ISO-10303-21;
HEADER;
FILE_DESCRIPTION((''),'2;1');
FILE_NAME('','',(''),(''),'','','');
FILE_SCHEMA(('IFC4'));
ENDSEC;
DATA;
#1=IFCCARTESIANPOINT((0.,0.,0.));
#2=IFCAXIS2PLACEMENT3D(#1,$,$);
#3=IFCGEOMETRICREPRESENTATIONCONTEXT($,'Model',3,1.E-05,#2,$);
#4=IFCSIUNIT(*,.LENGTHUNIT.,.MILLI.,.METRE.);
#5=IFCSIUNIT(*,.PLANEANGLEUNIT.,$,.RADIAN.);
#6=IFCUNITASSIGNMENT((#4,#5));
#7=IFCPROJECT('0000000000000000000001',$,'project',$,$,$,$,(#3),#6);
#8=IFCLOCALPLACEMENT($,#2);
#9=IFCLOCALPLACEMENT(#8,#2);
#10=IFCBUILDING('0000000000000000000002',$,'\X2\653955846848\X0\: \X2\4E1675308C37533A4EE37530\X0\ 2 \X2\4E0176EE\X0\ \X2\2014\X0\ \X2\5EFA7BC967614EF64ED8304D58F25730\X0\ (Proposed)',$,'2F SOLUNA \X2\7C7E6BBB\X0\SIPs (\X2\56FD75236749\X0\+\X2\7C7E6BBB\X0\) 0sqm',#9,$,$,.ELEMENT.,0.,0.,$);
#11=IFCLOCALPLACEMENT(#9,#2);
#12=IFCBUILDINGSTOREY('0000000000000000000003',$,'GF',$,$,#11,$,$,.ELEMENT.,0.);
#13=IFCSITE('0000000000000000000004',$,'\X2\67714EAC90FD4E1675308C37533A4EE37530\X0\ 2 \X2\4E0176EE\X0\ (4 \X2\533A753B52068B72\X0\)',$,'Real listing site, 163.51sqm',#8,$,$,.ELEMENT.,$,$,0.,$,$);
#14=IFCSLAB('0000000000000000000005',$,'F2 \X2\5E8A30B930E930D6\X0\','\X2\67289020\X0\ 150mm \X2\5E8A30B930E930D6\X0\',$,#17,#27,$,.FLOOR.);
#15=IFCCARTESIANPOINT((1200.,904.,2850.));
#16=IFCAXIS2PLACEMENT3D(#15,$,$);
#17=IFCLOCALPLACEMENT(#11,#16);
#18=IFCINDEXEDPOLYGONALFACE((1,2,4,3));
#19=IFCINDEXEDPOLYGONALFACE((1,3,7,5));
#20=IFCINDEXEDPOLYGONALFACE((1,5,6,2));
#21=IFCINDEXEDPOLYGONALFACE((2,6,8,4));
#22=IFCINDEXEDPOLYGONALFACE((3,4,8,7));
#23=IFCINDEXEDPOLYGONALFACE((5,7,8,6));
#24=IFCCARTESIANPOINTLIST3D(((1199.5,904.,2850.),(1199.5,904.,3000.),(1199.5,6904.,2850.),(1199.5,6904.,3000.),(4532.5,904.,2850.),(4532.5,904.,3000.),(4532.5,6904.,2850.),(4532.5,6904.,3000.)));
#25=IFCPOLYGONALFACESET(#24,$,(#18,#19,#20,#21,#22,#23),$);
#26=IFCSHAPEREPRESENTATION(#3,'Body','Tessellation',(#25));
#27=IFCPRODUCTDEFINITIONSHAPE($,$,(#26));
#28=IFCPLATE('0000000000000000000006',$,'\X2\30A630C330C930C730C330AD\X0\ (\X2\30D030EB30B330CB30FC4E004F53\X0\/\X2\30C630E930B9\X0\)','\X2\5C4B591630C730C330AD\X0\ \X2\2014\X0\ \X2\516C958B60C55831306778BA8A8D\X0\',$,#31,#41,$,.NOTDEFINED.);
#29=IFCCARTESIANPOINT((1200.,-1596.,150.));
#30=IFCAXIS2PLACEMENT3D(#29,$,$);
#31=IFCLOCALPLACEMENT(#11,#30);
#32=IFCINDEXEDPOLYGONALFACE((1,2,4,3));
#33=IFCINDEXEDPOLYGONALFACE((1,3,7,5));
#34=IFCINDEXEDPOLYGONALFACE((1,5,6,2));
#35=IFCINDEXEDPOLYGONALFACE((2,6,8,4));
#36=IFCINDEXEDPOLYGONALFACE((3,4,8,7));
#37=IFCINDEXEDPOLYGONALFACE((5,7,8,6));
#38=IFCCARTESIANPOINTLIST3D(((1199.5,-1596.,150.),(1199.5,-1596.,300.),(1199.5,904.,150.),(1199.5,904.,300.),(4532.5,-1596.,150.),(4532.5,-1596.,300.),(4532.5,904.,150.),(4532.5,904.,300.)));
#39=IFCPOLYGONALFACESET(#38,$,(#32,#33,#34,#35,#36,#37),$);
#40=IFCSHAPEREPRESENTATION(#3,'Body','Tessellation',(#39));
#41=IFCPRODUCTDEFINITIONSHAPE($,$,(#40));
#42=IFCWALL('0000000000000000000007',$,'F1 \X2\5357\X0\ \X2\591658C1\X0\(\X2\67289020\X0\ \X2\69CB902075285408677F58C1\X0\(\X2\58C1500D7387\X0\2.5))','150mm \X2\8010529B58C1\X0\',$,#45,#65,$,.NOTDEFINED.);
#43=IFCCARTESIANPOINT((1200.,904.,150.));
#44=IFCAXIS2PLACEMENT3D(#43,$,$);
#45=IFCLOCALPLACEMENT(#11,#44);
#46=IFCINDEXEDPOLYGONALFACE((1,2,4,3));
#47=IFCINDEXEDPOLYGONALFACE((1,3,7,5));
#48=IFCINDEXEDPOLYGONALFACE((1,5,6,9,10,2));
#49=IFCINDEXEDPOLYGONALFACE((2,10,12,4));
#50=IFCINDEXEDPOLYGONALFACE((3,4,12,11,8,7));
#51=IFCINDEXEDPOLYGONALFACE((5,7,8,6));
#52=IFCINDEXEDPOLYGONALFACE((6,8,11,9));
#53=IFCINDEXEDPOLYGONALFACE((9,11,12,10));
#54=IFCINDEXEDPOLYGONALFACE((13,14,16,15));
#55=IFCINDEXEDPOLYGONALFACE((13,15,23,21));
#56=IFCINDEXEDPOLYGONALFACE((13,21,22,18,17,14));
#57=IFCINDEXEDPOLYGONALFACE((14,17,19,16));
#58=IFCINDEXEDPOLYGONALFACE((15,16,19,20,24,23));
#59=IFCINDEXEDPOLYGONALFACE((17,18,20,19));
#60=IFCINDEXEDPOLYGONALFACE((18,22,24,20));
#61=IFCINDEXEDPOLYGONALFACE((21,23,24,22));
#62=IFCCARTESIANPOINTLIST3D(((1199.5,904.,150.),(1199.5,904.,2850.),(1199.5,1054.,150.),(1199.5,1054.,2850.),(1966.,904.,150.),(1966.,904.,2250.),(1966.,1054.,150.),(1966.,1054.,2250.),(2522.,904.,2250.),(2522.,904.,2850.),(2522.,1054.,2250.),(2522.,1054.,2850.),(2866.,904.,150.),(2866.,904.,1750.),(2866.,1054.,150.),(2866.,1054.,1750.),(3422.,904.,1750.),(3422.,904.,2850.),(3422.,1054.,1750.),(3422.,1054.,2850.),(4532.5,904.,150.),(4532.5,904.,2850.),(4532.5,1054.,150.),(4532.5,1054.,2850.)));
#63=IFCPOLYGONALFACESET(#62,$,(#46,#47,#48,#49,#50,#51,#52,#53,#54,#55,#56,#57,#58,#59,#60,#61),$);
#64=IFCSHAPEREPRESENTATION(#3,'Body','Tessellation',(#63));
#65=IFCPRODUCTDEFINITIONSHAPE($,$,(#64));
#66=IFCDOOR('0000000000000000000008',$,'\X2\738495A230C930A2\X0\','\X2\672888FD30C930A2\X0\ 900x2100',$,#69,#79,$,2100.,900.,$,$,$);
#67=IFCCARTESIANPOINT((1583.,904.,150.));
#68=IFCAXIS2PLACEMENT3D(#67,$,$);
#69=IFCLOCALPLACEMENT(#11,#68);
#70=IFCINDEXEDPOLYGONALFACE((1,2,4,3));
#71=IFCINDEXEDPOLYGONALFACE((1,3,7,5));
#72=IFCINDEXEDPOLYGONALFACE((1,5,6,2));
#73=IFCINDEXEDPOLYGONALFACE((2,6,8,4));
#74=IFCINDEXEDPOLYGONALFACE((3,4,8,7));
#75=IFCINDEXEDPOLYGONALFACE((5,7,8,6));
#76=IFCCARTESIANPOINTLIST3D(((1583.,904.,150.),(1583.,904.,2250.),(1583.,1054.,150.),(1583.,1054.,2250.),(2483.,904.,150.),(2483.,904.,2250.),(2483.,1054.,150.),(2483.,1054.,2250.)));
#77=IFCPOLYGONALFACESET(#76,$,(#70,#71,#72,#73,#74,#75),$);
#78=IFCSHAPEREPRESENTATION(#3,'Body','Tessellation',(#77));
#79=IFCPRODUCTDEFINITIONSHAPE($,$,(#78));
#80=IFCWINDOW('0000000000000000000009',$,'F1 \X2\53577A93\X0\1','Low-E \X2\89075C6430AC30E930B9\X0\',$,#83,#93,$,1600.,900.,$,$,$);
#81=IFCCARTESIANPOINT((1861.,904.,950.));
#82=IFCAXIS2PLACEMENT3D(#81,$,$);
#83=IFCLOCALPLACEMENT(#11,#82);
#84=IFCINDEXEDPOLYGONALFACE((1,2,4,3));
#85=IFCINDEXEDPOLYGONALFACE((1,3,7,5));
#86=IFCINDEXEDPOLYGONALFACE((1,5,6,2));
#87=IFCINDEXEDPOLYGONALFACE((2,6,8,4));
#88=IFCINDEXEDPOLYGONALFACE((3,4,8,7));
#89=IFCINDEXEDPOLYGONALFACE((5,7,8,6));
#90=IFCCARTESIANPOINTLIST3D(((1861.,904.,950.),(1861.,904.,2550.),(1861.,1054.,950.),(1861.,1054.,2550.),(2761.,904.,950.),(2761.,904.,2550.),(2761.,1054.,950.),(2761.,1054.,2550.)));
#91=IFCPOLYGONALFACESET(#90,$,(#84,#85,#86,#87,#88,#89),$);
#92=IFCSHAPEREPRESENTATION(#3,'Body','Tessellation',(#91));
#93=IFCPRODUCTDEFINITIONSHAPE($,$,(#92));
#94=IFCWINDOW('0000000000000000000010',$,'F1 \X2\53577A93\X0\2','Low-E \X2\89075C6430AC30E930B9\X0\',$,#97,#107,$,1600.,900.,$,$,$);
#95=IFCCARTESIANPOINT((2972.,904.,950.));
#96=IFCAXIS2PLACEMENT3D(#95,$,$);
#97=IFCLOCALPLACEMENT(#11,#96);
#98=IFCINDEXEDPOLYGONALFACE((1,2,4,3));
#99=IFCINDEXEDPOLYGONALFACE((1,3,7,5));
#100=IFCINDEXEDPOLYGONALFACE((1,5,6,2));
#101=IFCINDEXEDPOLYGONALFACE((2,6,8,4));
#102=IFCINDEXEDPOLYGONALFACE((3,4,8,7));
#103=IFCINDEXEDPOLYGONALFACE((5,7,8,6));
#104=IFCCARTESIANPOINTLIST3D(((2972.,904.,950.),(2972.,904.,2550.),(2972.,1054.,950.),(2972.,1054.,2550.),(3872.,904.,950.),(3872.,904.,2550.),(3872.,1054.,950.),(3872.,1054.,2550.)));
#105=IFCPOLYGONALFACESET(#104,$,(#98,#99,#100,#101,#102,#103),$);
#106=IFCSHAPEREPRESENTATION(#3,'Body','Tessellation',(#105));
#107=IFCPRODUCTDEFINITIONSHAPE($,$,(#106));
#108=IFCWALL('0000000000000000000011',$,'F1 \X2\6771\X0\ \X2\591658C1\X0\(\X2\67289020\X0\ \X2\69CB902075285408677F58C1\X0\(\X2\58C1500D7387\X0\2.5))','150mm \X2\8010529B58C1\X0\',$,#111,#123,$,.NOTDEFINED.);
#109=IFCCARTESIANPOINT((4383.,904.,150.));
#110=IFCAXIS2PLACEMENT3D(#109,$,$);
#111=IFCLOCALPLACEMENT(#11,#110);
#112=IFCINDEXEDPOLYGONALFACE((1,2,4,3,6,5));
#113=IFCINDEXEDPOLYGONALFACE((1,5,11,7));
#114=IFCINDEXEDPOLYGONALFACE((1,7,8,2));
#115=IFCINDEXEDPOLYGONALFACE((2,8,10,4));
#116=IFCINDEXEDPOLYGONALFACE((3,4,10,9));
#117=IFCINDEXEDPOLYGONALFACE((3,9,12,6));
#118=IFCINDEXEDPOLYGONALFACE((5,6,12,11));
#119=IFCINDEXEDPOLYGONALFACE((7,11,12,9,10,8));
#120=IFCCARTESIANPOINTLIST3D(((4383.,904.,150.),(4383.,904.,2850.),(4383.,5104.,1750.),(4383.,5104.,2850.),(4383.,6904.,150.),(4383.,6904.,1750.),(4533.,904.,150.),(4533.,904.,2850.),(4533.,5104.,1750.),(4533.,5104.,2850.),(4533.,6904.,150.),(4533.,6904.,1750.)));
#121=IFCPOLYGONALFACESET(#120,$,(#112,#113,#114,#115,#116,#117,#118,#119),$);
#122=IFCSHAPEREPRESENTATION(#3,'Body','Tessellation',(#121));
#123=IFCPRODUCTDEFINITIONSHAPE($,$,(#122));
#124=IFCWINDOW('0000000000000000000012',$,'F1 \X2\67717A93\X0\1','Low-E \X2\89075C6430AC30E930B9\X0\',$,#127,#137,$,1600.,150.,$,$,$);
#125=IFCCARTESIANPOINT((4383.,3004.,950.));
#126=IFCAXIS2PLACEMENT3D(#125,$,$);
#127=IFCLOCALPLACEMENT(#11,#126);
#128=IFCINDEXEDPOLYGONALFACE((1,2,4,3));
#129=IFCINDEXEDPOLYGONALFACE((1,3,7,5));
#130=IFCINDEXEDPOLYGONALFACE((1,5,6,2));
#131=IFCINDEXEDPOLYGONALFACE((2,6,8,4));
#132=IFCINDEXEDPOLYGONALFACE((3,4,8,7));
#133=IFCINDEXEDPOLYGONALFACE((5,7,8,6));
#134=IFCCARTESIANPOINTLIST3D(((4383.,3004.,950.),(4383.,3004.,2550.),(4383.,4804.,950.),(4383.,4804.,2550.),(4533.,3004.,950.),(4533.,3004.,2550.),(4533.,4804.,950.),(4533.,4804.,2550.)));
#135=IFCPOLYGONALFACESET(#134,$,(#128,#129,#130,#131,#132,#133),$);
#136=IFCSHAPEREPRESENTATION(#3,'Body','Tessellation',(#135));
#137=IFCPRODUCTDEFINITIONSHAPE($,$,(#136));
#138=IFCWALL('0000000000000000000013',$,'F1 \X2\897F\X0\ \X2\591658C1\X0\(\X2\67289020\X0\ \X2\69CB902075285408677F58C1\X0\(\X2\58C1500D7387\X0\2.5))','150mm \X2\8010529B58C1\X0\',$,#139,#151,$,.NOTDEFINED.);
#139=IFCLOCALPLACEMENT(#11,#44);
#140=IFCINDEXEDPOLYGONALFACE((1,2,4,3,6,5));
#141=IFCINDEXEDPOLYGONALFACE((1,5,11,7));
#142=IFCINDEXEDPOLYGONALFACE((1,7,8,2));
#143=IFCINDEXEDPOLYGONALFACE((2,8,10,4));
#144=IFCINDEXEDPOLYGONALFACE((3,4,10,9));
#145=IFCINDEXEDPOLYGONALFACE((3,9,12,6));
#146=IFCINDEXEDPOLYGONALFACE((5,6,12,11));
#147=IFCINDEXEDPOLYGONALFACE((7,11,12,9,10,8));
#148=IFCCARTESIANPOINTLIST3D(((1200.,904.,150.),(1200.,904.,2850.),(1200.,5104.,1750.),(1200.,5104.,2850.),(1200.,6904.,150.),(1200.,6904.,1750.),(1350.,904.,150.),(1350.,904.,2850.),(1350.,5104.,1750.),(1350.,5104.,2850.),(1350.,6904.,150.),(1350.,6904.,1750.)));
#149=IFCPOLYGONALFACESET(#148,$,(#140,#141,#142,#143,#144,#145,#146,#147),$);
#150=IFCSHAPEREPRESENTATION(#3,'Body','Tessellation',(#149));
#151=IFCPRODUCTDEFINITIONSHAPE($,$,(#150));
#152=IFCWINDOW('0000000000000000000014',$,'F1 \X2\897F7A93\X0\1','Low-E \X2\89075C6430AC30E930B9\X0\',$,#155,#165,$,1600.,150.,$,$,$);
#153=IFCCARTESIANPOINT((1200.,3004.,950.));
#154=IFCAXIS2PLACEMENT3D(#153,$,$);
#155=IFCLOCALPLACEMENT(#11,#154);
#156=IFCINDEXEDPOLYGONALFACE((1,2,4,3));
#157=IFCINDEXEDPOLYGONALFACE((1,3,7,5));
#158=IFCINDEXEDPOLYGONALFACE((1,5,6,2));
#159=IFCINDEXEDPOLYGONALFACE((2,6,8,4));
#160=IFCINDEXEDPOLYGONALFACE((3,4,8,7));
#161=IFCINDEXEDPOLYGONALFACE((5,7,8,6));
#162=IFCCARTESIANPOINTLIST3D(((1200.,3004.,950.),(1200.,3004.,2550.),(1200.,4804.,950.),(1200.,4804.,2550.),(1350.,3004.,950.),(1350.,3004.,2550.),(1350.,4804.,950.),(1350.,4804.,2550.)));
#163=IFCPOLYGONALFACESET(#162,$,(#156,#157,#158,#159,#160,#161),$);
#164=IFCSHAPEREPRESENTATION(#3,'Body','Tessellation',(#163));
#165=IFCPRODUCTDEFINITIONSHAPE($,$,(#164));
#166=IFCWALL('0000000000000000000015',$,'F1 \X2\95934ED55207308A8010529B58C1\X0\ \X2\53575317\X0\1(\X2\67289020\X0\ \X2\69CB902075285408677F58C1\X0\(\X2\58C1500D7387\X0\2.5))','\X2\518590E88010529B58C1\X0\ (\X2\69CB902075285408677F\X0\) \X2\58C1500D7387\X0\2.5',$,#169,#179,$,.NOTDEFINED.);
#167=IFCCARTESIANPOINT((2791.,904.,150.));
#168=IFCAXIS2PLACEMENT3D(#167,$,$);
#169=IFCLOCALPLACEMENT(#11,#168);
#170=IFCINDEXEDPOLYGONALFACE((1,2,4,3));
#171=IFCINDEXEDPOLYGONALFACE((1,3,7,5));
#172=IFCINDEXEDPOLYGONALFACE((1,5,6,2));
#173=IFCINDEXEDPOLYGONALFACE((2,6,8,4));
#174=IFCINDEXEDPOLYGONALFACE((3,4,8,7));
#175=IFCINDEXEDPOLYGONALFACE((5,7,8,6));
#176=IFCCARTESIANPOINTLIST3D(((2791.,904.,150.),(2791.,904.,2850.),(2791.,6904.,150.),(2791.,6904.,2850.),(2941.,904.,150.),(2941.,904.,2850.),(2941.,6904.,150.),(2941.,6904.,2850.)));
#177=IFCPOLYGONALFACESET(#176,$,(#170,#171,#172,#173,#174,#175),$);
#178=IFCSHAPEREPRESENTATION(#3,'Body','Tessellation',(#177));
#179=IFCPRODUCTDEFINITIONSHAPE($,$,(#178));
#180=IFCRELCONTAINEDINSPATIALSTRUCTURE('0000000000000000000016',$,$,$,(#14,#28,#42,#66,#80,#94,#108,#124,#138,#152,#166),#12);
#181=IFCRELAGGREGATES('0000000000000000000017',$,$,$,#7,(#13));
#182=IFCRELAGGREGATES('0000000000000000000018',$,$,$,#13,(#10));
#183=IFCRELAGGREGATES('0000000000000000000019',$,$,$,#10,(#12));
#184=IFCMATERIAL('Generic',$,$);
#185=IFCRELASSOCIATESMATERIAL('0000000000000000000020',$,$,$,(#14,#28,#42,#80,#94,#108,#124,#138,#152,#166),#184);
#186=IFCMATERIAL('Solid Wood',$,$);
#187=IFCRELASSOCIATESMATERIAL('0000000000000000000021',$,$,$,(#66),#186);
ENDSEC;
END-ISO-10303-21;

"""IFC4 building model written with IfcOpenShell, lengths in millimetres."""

from ifc_helpers import new_model, si_unit, frame, frame_2d, origin, place, context, project, spatial, rectangle, extrude, material, element, fill, save


model = new_model("IFC4")

# Units and contexts
model_context = context("Model", 3, precision=1e-05, world=origin())
ifc_project = project(units=[si_unit("LENGTHUNIT", "METRE", prefix="MILLI"), si_unit("PLANEANGLEUNIT", "RADIAN")], contexts=[model_context])

# Site, building, storey
site_placement = place(None, origin())
site = spatial("IfcSite", under=ifc_project, at=site_placement, Name="東京都世田谷区代田 2 丁目 (4 区画分譲)", ObjectType="Real listing site, 163.51sqm", CompositionType="ELEMENT", RefElevation=0.0)
building_placement = place(site_placement, origin())
building = spatial("IfcBuilding", under=site, at=building_placement, Name="改善案: 世田谷区代田 2 丁目 — 建築条件付き売地 (Proposed)", ObjectType="2F SOLUNA 籾殻SIPs (国産杉+籾殻) 0sqm", CompositionType="ELEMENT", ElevationOfRefHeight=0.0, ElevationOfTerrain=0.0)
storey_placement = place(building_placement, origin())
storey = spatial("IfcBuildingStorey", under=building, at=storey_placement, Name="GF", CompositionType="ELEMENT", Elevation=0.0)

# Slab
ifc_material_1 = material(Name="Generic")
slab_1_placement = place(storey_placement, frame((1200.0, 904.0, 2850.0)))
element("IfcSlab", 1, at=slab_1_placement, inside=storey, material=ifc_material_1, Name="F2 床スラブ", Description="木造 150mm 床スラブ", PredefinedType="FLOOR", context=model_context, shape_type="SweptSolid", body=[
    extrude(rectangle(XDim=3333.0, YDim=6000.0, at=frame_2d((1666.0, 3000.0))), frame((1200.0, 904.0, 2850.0)), (0.0, 0.0, 1.0), 150.0),
])

# Plate
plate_placement = place(storey_placement, frame((1200.0, -1596.0, 150.0)))
element("IfcPlate", 2, at=plate_placement, inside=storey, material=ifc_material_1, Name="ウッドデッキ (バルコニー一体/テラス)", Description="屋外デッキ — 公開情報で確認", PredefinedType="NOTDEFINED", context=model_context, shape_type="SweptSolid", body=[
    extrude(rectangle(XDim=3333.0, YDim=2500.0, at=frame_2d((1666.0, 1250.0))), frame((1200.0, -1596.0, 150.0)), (0.0, 0.0, 1.0), 150.0),
])

# Wall, openings, door, windows
wall_1_placement = place(storey_placement, frame((1200.0, 904.0, 150.0)))
wall_1 = element("IfcWall", 3, at=wall_1_placement, inside=storey, material=ifc_material_1, Name="F1 南 外壁(木造 構造用合板壁(壁倍率2.5))", Description="150mm 耐力壁", PredefinedType="NOTDEFINED", context=model_context, shape_type="SweptSolid", body=[
    extrude(rectangle(XDim=3333.0, YDim=150.0, at=frame_2d((1666.0, 75.0))), frame((1200.0, 904.0, 150.0)), (0.0, 0.0, 1.0), 2700.0),
])
opening_1_placement = place(storey_placement, frame((1583.0, 904.0, 150.0)))
opening_1 = element("IfcOpeningElement", 4, at=opening_1_placement, cuts=wall_1, PredefinedType="NOTDEFINED", context=model_context, shape_type="SweptSolid", body=[
    extrude(rectangle(XDim=900.0, YDim=150.0, at=frame_2d((450.0, 75.0))), frame((1583.0, 904.0, 150.0)), (0.0, 0.0, 1.0), 2100.0),
])
opening_2_placement = place(storey_placement, frame((1861.0, 904.0, 950.0)))
opening_2 = element("IfcOpeningElement", 5, at=opening_2_placement, cuts=wall_1, PredefinedType="NOTDEFINED", context=model_context, shape_type="SweptSolid", body=[
    extrude(rectangle(XDim=900.0, YDim=150.0, at=frame_2d((450.0, 75.0))), frame((1861.0, 904.0, 950.0)), (0.0, 0.0, 1.0), 1600.0),
])
opening_3_placement = place(storey_placement, frame((2972.0, 904.0, 950.0)))
opening_3 = element("IfcOpeningElement", 6, at=opening_3_placement, cuts=wall_1, PredefinedType="NOTDEFINED", context=model_context, shape_type="SweptSolid", body=[
    extrude(rectangle(XDim=900.0, YDim=150.0, at=frame_2d((450.0, 75.0))), frame((2972.0, 904.0, 950.0)), (0.0, 0.0, 1.0), 1600.0),
])
ifc_material_2 = material(Name="Solid Wood")
door_placement = place(storey_placement, frame((1583.0, 904.0, 150.0)))
door = element("IfcDoor", 7, at=door_placement, inside=storey, material=ifc_material_2, Name="玄関ドア", Description="木製ドア 900x2100", OverallHeight=2100.0, OverallWidth=900.0, context=model_context, shape_type="SweptSolid", body=[
    extrude(rectangle(XDim=900.0, YDim=150.0, at=frame_2d((450.0, 75.0))), frame((1583.0, 904.0, 150.0)), (0.0, 0.0, 1.0), 2100.0),
])
fill(opening_1, door)
window_1_placement = place(storey_placement, frame((1861.0, 904.0, 950.0)))
window_1 = element("IfcWindow", 8, at=window_1_placement, inside=storey, material=ifc_material_1, Name="F1 南窓1", Description="Low-E 複層ガラス", OverallHeight=1600.0, OverallWidth=900.0, context=model_context, shape_type="SweptSolid", body=[
    extrude(rectangle(XDim=900.0, YDim=150.0, at=frame_2d((450.0, 75.0))), frame((1861.0, 904.0, 950.0)), (0.0, 0.0, 1.0), 1600.0),
])
fill(opening_2, window_1)
window_2_placement = place(storey_placement, frame((2972.0, 904.0, 950.0)))
window_2 = element("IfcWindow", 9, at=window_2_placement, inside=storey, material=ifc_material_1, Name="F1 南窓2", Description="Low-E 複層ガラス", OverallHeight=1600.0, OverallWidth=900.0, context=model_context, shape_type="SweptSolid", body=[
    extrude(rectangle(XDim=900.0, YDim=150.0, at=frame_2d((450.0, 75.0))), frame((2972.0, 904.0, 950.0)), (0.0, 0.0, 1.0), 1600.0),
])
fill(opening_3, window_2)

# Walls, openings, windows
wall_2_placement = place(storey_placement, frame((4383.0, 904.0, 150.0)))
wall_2 = element("IfcWall", 10, at=wall_2_placement, inside=storey, material=ifc_material_1, Name="F1 東 外壁(木造 構造用合板壁(壁倍率2.5))", Description="150mm 耐力壁", PredefinedType="NOTDEFINED", context=model_context, shape_type="SweptSolid", body=[
    extrude(rectangle(XDim=150.0, YDim=6000.0, at=frame_2d((75.0, 3000.0))), frame((4383.0, 904.0, 150.0)), (0.0, 0.0, 1.0), 2700.0),
])
opening_4_placement = place(storey_placement, frame((4383.0, 3004.0, 950.0)))
opening_4 = element("IfcOpeningElement", 11, at=opening_4_placement, cuts=wall_2, PredefinedType="NOTDEFINED", context=model_context, shape_type="SweptSolid", body=[
    extrude(rectangle(XDim=150.0, YDim=1800.0, at=frame_2d((75.0, 900.0))), frame((4383.0, 3004.0, 950.0)), (0.0, 0.0, 1.0), 1600.0),
])
window_3_placement = place(storey_placement, frame((4383.0, 3004.0, 950.0)))
window_3 = element("IfcWindow", 12, at=window_3_placement, inside=storey, material=ifc_material_1, Name="F1 東窓1", Description="Low-E 複層ガラス", OverallHeight=1600.0, OverallWidth=150.0, context=model_context, shape_type="SweptSolid", body=[
    extrude(rectangle(XDim=150.0, YDim=1800.0, at=frame_2d((75.0, 900.0))), frame((4383.0, 3004.0, 950.0)), (0.0, 0.0, 1.0), 1600.0),
])
fill(opening_4, window_3)
wall_3_placement = place(storey_placement, frame((1200.0, 904.0, 150.0)))
wall_3 = element("IfcWall", 13, at=wall_3_placement, inside=storey, material=ifc_material_1, Name="F1 西 外壁(木造 構造用合板壁(壁倍率2.5))", Description="150mm 耐力壁", PredefinedType="NOTDEFINED", context=model_context, shape_type="SweptSolid", body=[
    extrude(rectangle(XDim=150.0, YDim=6000.0, at=frame_2d((75.0, 3000.0))), frame((1200.0, 904.0, 150.0)), (0.0, 0.0, 1.0), 2700.0),
])
opening_5_placement = place(storey_placement, frame((1200.0, 3004.0, 950.0)))
opening_5 = element("IfcOpeningElement", 14, at=opening_5_placement, cuts=wall_3, PredefinedType="NOTDEFINED", context=model_context, shape_type="SweptSolid", body=[
    extrude(rectangle(XDim=150.0, YDim=1800.0, at=frame_2d((75.0, 900.0))), frame((1200.0, 3004.0, 950.0)), (0.0, 0.0, 1.0), 1600.0),
])
window_4_placement = place(storey_placement, frame((1200.0, 3004.0, 950.0)))
window_4 = element("IfcWindow", 15, at=window_4_placement, inside=storey, material=ifc_material_1, Name="F1 西窓1", Description="Low-E 複層ガラス", OverallHeight=1600.0, OverallWidth=150.0, context=model_context, shape_type="SweptSolid", body=[
    extrude(rectangle(XDim=150.0, YDim=1800.0, at=frame_2d((75.0, 900.0))), frame((1200.0, 3004.0, 950.0)), (0.0, 0.0, 1.0), 1600.0),
])
fill(opening_5, window_4)

# Wall
wall_4_placement = place(storey_placement, frame((2791.0, 904.0, 150.0)))
element("IfcWall", 16, at=wall_4_placement, inside=storey, material=ifc_material_1, Name="F1 間仕切り耐力壁 南北1(木造 構造用合板壁(壁倍率2.5))", Description="内部耐力壁 (構造用合板) 壁倍率2.5", PredefinedType="NOTDEFINED", context=model_context, shape_type="SweptSolid", body=[
    extrude(rectangle(XDim=150.0, YDim=6000.0, at=frame_2d((75.0, 3000.0))), frame((2791.0, 904.0, 150.0)), (0.0, 0.0, 1.0), 2700.0),
])

save(model, "model.ifc")
